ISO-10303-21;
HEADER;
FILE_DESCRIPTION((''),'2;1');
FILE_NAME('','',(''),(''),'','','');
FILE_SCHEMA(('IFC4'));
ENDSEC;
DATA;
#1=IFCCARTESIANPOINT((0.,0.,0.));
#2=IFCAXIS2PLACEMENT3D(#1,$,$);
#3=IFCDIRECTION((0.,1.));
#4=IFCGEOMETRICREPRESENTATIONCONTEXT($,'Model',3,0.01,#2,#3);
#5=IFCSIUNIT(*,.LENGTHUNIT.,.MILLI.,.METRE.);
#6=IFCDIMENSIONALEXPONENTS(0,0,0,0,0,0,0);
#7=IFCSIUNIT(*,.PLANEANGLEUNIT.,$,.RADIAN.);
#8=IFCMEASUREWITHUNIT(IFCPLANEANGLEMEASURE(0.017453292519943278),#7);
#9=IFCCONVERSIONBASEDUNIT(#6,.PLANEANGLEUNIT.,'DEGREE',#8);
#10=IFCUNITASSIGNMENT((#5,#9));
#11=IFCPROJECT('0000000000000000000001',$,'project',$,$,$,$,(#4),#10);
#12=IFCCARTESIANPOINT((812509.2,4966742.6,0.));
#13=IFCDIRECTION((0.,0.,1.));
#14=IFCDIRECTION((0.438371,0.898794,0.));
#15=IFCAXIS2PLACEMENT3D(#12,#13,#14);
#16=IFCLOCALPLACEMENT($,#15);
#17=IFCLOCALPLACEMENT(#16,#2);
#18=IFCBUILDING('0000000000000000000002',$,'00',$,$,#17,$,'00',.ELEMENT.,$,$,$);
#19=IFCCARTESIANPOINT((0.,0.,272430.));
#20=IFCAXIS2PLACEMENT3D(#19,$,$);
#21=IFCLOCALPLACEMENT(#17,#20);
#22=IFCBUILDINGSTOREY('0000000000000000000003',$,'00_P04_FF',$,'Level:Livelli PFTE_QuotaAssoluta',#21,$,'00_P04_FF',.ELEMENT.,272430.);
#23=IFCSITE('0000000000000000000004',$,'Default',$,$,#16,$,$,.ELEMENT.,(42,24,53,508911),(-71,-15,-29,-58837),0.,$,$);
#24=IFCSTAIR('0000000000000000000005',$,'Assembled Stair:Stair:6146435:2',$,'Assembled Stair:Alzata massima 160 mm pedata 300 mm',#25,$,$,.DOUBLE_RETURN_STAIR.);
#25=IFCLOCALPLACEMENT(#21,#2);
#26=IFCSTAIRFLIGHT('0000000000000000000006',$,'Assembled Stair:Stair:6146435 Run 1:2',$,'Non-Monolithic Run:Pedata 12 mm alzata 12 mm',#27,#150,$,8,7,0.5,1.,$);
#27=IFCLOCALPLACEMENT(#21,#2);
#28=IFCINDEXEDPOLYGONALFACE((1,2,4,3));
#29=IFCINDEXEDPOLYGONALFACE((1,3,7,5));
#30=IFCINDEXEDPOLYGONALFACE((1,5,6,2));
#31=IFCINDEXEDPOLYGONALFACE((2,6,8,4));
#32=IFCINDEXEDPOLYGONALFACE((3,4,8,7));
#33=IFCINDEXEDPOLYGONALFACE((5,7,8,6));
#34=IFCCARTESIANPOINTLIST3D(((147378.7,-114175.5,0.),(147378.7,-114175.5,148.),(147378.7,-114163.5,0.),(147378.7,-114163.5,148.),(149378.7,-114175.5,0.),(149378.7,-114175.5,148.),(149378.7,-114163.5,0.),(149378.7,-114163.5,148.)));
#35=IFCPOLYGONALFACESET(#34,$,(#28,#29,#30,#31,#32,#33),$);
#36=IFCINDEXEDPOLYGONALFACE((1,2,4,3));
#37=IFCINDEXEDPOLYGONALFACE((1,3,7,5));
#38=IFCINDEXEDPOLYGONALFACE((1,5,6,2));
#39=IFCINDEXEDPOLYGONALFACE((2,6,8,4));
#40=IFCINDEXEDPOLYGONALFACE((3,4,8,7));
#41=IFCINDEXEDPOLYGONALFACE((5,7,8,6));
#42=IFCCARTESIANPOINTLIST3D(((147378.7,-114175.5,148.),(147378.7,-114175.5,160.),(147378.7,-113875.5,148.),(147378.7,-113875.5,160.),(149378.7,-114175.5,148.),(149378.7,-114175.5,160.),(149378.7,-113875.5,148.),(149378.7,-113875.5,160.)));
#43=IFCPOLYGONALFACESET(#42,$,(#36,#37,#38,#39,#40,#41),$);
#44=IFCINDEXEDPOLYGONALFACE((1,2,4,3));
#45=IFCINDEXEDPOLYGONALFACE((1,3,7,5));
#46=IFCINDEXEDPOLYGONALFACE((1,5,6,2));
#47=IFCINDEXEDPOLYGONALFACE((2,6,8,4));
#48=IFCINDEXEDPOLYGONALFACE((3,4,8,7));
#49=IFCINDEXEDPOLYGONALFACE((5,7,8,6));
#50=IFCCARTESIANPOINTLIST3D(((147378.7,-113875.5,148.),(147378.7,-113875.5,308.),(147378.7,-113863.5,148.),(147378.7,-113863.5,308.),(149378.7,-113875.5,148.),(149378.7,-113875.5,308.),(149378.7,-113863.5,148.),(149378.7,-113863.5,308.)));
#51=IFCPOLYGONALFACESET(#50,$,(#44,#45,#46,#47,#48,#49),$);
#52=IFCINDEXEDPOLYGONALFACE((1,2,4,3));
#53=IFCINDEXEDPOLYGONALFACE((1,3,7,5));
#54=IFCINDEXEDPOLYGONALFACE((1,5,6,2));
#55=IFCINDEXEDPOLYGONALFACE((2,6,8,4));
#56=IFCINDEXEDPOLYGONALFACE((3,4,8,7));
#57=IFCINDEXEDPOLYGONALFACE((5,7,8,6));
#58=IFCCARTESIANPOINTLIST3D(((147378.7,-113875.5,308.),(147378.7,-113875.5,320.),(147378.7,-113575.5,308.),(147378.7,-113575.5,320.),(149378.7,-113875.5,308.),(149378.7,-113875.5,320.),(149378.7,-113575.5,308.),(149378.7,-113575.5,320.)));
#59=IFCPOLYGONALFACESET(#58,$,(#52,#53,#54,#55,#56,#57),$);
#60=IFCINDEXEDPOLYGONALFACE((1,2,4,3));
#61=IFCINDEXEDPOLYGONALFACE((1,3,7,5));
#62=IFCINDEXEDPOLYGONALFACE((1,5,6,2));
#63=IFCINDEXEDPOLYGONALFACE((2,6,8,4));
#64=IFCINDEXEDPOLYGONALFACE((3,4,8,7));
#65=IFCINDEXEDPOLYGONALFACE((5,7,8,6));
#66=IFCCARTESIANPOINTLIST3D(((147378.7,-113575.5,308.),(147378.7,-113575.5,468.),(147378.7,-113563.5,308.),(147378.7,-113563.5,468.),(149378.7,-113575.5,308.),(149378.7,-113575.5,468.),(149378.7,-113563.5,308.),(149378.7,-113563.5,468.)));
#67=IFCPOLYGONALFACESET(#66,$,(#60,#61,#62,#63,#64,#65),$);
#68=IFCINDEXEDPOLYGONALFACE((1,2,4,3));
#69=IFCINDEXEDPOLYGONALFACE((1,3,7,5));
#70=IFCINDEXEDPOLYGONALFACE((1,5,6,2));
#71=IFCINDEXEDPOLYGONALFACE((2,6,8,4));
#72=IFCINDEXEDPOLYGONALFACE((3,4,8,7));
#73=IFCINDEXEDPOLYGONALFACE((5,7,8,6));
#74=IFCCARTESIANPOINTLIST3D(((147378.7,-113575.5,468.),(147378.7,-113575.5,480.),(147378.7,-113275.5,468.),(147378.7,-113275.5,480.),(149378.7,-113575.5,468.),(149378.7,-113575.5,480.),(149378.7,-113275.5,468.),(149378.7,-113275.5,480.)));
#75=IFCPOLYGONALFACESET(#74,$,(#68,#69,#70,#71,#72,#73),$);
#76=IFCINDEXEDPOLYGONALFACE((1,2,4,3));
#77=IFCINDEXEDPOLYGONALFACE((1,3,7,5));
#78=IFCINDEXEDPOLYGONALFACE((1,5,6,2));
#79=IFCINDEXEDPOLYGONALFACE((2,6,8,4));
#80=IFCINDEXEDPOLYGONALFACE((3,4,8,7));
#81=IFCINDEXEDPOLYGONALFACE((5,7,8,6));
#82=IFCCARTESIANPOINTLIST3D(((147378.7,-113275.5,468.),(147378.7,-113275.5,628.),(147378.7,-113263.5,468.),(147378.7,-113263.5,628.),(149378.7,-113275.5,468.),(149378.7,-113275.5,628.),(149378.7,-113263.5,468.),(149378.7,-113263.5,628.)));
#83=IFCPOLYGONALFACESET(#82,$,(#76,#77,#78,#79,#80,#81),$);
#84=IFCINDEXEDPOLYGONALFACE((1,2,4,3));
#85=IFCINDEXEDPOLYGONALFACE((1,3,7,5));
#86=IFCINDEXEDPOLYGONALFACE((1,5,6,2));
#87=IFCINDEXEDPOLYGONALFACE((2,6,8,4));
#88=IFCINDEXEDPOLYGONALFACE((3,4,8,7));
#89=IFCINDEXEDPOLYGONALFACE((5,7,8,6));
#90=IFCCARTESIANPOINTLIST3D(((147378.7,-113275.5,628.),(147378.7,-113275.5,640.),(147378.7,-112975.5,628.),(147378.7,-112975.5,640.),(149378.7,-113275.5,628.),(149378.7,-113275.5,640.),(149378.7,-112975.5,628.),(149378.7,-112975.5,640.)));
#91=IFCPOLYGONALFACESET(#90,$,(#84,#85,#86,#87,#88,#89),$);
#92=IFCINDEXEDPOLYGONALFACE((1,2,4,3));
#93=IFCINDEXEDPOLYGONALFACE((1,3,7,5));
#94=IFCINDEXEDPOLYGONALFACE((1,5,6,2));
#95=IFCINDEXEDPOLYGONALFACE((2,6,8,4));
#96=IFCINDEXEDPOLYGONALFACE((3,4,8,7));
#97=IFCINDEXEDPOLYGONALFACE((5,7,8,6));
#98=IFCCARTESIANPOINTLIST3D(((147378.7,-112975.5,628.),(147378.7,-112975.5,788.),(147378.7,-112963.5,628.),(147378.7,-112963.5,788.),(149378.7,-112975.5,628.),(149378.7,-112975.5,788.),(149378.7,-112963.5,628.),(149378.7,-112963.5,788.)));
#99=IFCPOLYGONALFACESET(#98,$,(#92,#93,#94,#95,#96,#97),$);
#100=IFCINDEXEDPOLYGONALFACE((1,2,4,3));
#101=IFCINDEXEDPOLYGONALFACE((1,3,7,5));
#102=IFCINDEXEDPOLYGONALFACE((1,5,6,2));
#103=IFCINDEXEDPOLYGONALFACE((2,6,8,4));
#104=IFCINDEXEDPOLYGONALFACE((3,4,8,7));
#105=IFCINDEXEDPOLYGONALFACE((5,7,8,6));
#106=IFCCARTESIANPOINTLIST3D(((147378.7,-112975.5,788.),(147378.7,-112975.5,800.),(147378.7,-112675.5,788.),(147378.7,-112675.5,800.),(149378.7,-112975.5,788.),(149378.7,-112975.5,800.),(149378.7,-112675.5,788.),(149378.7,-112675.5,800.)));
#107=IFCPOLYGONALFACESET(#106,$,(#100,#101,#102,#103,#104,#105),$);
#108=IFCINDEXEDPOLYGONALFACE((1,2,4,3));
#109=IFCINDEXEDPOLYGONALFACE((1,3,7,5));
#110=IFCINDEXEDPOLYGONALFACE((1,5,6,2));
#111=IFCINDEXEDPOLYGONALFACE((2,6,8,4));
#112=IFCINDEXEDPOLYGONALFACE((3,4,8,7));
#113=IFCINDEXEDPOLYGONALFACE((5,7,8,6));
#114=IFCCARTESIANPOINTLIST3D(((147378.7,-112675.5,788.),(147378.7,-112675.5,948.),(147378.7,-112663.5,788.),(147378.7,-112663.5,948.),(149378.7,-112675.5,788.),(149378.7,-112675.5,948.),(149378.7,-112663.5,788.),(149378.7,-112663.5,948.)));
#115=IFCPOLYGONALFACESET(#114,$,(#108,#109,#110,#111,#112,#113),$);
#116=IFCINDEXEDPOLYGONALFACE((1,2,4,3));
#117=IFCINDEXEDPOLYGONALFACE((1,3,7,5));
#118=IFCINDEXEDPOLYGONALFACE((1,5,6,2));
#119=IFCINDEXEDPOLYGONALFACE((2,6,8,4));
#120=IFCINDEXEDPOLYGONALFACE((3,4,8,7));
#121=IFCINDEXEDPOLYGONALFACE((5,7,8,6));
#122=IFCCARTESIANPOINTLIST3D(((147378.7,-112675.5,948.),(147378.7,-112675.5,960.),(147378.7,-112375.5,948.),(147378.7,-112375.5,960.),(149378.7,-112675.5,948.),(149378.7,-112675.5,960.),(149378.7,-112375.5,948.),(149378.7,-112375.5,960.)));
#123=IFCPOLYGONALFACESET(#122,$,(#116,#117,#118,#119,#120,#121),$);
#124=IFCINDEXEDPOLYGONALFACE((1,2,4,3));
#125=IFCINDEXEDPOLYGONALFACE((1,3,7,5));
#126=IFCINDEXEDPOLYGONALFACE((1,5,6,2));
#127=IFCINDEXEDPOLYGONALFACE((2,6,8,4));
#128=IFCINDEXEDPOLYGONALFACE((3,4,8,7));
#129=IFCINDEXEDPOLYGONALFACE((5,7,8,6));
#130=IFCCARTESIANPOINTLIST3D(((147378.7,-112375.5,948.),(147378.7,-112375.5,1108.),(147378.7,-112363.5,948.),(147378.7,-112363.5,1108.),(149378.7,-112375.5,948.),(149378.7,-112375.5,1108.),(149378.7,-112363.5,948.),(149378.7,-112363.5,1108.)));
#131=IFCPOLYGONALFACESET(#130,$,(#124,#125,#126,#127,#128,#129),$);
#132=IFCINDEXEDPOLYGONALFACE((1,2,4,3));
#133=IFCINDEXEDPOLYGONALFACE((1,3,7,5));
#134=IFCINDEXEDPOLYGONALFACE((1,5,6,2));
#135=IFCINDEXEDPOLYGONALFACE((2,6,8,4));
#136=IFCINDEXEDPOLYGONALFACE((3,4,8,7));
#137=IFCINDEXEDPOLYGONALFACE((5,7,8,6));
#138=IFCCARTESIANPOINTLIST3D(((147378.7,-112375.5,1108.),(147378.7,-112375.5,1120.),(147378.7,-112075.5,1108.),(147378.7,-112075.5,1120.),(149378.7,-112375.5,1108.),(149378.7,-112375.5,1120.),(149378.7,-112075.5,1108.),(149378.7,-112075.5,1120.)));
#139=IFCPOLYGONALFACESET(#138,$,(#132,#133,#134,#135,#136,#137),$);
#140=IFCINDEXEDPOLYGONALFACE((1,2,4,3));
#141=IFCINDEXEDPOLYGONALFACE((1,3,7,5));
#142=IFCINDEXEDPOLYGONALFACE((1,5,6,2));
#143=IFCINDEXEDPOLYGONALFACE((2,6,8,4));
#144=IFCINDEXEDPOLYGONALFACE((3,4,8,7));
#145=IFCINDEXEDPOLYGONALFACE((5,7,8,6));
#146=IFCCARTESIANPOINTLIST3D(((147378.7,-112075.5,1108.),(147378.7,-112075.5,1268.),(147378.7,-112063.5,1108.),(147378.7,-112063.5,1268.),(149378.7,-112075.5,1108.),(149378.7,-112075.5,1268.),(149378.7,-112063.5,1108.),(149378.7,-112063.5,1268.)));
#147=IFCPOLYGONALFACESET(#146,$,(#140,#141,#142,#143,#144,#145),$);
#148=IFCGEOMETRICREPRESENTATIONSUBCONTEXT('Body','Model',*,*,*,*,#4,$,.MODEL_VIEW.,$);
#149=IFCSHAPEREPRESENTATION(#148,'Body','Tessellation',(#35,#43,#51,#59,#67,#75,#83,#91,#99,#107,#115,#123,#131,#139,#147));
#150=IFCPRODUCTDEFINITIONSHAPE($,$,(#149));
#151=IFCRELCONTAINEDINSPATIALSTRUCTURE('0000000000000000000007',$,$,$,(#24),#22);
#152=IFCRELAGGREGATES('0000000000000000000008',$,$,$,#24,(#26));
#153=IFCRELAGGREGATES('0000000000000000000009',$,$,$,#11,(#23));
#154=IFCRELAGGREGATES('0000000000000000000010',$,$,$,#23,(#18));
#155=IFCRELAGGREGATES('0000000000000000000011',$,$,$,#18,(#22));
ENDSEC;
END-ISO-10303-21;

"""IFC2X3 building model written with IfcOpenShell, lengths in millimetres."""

from ifc_helpers import new_model, entity, si_unit, converted_unit, direction, frame, origin, origin_2d_with_axis, place, context, subcontext, project, spatial, rectangle, extrude, element, aggregate, save


model = new_model("IFC2X3")

# Units and contexts
model_context = context("Model", 3, precision=0.01, world=origin(), true_north=direction((0.0, 1.0)))
body_context = subcontext(model_context, "Body", "Model", "MODEL_VIEW")
ifc_project = project(units=[si_unit("LENGTHUNIT", "METRE", prefix="MILLI"), converted_unit("PLANEANGLEUNIT", "DEGREE", entity("IfcPlaneAngleMeasure", 0.017453292519943278), si_unit("PLANEANGLEUNIT", "RADIAN"), dimensions=[0, 0, 0, 0, 0, 0, 0])], contexts=[model_context])

# Site, building, storey
site_placement = place(None, frame((812509.2, 4966742.6, 0.0), z_axis=(0.0, 0.0, 1.0), x_axis=(0.438371, 0.898794, 0.0)))
site = spatial("IfcSite", under=ifc_project, at=site_placement, Name="Default", CompositionType="ELEMENT", RefLatitude=(42, 24, 53, 508911), RefLongitude=(-71, -15, -29, -58837), RefElevation=0.0)
building_placement = place(site_placement, origin())
building = spatial("IfcBuilding", under=site, at=building_placement, Name="00", LongName="00", CompositionType="ELEMENT")
storey_placement = place(building_placement, frame((0.0, 0.0, 272430.0)))
storey = spatial("IfcBuildingStorey", under=building, at=storey_placement, Name="00_P04_FF", ObjectType="Level:Livelli PFTE_QuotaAssoluta", LongName="00_P04_FF", CompositionType="ELEMENT", Elevation=272430.0)

# Stair
stair_1_placement = place(storey_placement, origin())
stair_1 = element("IfcStair", 1, at=stair_1_placement, inside=storey, Name="Assembled Stair:Stair:6146435:2", ObjectType="Assembled Stair:Alzata massima 160 mm pedata 300 mm", ShapeType="DOUBLE_RETURN_STAIR")

# Stair flight
stair_flight_1_placement = place(stair_1_placement, origin())
stair_flight_1 = element("IfcStairFlight", 2, at=stair_flight_1_placement, Name="Assembled Stair:Stair:6146435 Run 1:2", ObjectType="Non-Monolithic Run:Pedata 12 mm alzata 12 mm", NumberOfRiser=8, NumberOfTreads=7, RiserHeight=0.5, TreadLength=1.0, context=body_context, shape_type="SweptSolid", body=[
    extrude(rectangle(XDim=2000.0, YDim=12.0, at=origin_2d_with_axis()), frame((148378.7, -114169.5, 0.0), z_axis=(0.0, 0.0, 1.0), x_axis=(-1.0, 0.0, 0.0)), (0.0, 0.0, 1.0), 148.0),
    extrude(rectangle(XDim=300.0, YDim=2000.0, at=origin_2d_with_axis()), frame((148378.7, -114025.5, 148.0), z_axis=(0.0, 0.0, 1.0), x_axis=(0.0, -1.0, 0.0)), (0.0, 0.0, 1.0), 12.0),
    extrude(rectangle(XDim=2000.0, YDim=12.0, at=origin_2d_with_axis()), frame((148378.7, -113869.5, 148.0), z_axis=(0.0, 0.0, 1.0), x_axis=(-1.0, 0.0, 0.0)), (0.0, 0.0, 1.0), 160.0),
    extrude(rectangle(XDim=300.0, YDim=2000.0, at=origin_2d_with_axis()), frame((148378.7, -113725.5, 308.0), z_axis=(0.0, 0.0, 1.0), x_axis=(0.0, -1.0, 0.0)), (0.0, 0.0, 1.0), 12.0),
    extrude(rectangle(XDim=2000.0, YDim=12.0, at=origin_2d_with_axis()), frame((148378.7, -113569.5, 308.0), z_axis=(0.0, 0.0, 1.0), x_axis=(-1.0, 0.0, 0.0)), (0.0, 0.0, 1.0), 160.0),
    extrude(rectangle(XDim=300.0, YDim=2000.0, at=origin_2d_with_axis()), frame((148378.7, -113425.5, 468.0), z_axis=(0.0, 0.0, 1.0), x_axis=(0.0, -1.0, 0.0)), (0.0, 0.0, 1.0), 12.0),
    extrude(rectangle(XDim=2000.0, YDim=12.0, at=origin_2d_with_axis()), frame((148378.7, -113269.5, 468.0), z_axis=(0.0, 0.0, 1.0), x_axis=(-1.0, 0.0, 0.0)), (0.0, 0.0, 1.0), 160.0),
    extrude(rectangle(XDim=300.0, YDim=2000.0, at=origin_2d_with_axis()), frame((148378.7, -113125.5, 628.0), z_axis=(0.0, 0.0, 1.0), x_axis=(0.0, -1.0, 0.0)), (0.0, 0.0, 1.0), 12.0),
    extrude(rectangle(XDim=2000.0, YDim=12.0, at=origin_2d_with_axis()), frame((148378.7, -112969.5, 628.0), z_axis=(0.0, 0.0, 1.0), x_axis=(-1.0, 0.0, 0.0)), (0.0, 0.0, 1.0), 160.0),
    extrude(rectangle(XDim=300.0, YDim=2000.0, at=origin_2d_with_axis()), frame((148378.7, -112825.5, 788.0), z_axis=(0.0, 0.0, 1.0), x_axis=(0.0, -1.0, 0.0)), (0.0, 0.0, 1.0), 12.0),
    extrude(rectangle(XDim=2000.0, YDim=12.0, at=origin_2d_with_axis()), frame((148378.7, -112669.5, 788.0), z_axis=(0.0, 0.0, 1.0), x_axis=(-1.0, 0.0, 0.0)), (0.0, 0.0, 1.0), 160.0),
    extrude(rectangle(XDim=300.0, YDim=2000.0, at=origin_2d_with_axis()), frame((148378.7, -112525.5, 948.0), z_axis=(0.0, 0.0, 1.0), x_axis=(0.0, -1.0, 0.0)), (0.0, 0.0, 1.0), 12.0),
    extrude(rectangle(XDim=2000.0, YDim=12.0, at=origin_2d_with_axis()), frame((148378.7, -112369.5, 948.0), z_axis=(0.0, 0.0, 1.0), x_axis=(-1.0, 0.0, 0.0)), (0.0, 0.0, 1.0), 160.0),
    extrude(rectangle(XDim=300.0, YDim=2000.0, at=origin_2d_with_axis()), frame((148378.7, -112225.5, 1108.0), z_axis=(0.0, 0.0, 1.0), x_axis=(0.0, -1.0, 0.0)), (0.0, 0.0, 1.0), 12.0),
    extrude(rectangle(XDim=2000.0, YDim=12.0, at=origin_2d_with_axis()), frame((148378.7, -112069.5, 1108.0), z_axis=(0.0, 0.0, 1.0), x_axis=(-1.0, 0.0, 0.0)), (0.0, 0.0, 1.0), 160.0),
])
aggregate(stair_1, [stair_flight_1])

save(model, "model.ifc")
